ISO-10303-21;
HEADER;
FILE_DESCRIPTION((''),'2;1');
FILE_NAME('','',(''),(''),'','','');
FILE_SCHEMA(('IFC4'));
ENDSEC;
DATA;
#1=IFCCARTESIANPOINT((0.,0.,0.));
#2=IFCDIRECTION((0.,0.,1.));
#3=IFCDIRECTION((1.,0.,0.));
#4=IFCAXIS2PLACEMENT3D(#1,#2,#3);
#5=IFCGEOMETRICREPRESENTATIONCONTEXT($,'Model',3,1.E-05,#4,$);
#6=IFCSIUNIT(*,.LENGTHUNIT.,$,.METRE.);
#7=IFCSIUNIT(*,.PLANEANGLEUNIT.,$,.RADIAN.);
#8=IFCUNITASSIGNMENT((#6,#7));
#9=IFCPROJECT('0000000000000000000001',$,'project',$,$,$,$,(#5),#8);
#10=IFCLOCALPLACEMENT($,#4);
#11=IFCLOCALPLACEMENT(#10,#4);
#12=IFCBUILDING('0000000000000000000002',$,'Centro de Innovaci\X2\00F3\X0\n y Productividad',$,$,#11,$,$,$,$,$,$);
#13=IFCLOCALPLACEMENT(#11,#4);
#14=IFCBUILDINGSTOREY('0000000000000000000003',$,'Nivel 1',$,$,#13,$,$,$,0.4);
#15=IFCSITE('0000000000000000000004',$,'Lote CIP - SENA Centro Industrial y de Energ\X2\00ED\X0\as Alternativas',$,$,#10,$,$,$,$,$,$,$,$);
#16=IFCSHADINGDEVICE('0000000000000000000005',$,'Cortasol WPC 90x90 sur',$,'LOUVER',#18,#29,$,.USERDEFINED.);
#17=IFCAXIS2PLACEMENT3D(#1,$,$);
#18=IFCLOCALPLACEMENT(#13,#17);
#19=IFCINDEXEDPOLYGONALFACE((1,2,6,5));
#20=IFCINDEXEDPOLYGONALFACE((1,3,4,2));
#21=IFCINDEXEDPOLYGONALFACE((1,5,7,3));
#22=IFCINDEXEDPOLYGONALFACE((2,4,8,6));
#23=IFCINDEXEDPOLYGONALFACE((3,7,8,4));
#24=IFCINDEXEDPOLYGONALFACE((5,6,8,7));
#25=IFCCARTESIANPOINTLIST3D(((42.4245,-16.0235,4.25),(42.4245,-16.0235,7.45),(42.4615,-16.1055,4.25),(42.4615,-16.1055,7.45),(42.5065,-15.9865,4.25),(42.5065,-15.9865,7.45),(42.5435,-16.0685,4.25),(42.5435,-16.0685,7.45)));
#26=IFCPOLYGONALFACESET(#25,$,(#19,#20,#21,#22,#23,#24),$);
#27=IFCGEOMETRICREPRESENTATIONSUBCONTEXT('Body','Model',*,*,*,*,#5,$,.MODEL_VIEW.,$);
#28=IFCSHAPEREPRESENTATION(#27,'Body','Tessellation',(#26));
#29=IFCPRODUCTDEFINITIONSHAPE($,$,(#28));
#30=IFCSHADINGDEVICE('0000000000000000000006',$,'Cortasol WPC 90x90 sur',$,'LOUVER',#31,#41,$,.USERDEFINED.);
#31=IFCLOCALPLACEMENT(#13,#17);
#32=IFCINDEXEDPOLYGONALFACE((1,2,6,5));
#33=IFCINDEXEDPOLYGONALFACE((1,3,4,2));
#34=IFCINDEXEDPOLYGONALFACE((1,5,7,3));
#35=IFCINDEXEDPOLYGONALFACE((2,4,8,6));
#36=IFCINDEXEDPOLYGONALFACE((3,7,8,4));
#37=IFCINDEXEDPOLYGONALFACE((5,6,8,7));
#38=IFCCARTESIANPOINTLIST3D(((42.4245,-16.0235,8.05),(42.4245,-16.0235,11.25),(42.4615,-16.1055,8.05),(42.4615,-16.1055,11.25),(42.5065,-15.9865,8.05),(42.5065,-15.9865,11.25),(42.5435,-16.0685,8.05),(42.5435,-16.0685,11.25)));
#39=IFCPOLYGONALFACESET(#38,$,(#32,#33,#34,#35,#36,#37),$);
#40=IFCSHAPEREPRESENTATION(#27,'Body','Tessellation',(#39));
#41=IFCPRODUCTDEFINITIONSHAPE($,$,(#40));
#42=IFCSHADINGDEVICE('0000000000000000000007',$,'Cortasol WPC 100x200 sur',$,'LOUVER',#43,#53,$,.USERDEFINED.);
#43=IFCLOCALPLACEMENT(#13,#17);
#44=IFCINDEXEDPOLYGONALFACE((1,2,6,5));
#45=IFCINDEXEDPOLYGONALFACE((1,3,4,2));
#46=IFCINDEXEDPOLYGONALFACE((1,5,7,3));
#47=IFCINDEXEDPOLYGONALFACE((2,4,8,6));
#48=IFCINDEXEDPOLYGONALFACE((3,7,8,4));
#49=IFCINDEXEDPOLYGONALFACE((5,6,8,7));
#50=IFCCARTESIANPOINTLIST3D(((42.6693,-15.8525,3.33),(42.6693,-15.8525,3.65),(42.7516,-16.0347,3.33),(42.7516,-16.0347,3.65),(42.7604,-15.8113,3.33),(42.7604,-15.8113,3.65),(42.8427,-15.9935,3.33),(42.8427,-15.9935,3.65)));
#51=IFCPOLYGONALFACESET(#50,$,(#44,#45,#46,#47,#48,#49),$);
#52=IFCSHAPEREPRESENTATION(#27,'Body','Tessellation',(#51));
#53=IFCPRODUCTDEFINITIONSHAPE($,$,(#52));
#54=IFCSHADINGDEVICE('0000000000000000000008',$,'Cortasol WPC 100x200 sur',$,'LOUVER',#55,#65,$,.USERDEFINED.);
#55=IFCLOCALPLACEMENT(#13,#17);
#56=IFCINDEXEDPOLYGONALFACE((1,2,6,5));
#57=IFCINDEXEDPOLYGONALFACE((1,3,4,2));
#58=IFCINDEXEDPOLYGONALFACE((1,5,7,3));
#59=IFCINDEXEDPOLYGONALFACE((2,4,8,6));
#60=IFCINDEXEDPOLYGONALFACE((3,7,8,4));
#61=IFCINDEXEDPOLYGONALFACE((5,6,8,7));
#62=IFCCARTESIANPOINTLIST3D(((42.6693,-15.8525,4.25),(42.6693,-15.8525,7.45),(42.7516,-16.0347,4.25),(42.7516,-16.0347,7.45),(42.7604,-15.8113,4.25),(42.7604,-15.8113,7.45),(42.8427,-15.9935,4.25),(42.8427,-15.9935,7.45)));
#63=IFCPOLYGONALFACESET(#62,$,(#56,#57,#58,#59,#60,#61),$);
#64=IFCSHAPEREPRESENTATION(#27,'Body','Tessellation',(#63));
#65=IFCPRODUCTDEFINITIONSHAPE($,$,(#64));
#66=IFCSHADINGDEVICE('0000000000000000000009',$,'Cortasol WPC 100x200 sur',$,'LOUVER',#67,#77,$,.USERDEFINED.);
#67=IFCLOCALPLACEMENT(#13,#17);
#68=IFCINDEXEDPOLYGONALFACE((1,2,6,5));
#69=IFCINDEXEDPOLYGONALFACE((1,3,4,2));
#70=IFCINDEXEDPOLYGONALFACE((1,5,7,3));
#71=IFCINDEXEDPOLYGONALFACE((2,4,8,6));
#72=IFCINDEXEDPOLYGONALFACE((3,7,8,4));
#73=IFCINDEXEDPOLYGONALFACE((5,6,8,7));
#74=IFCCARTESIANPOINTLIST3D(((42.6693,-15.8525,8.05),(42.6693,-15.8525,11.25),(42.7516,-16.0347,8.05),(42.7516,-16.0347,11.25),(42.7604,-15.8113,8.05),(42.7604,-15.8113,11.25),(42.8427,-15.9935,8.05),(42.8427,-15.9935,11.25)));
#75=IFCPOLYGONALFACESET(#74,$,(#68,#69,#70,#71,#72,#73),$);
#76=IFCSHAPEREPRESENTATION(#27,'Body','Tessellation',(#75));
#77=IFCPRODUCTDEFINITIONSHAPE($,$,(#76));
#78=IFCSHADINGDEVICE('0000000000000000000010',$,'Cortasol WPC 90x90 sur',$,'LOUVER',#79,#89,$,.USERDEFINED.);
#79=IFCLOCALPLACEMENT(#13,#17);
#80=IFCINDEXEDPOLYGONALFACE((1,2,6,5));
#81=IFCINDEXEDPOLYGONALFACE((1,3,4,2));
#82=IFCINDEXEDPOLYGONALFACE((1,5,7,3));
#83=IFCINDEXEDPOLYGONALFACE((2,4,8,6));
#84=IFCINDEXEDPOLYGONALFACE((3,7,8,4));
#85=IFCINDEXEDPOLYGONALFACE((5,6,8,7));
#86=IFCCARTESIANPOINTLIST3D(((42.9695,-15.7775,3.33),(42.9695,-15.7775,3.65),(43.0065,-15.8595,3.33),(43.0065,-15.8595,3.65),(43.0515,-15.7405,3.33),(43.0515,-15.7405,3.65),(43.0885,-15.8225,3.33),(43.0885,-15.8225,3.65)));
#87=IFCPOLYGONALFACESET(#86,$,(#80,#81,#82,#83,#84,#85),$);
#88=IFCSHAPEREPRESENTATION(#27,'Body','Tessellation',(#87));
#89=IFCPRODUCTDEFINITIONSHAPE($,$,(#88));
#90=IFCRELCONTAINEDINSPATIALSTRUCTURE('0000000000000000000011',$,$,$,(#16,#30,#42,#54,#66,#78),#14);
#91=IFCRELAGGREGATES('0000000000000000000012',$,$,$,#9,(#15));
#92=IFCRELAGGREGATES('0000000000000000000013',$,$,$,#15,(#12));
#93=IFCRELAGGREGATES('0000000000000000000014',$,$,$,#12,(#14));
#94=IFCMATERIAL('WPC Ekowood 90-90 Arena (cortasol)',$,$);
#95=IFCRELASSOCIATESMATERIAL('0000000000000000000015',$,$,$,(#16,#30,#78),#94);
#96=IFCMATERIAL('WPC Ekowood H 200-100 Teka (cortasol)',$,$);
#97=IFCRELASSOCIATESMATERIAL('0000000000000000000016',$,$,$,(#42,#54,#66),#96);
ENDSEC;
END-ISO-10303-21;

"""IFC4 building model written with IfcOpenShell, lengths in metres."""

from ifc_helpers import new_model, si_unit, frame, origin_with_axes, place, context, subcontext, project, spatial, polyline, outline, extrude, material, element, save


model = new_model("IFC4")

# Units and contexts
model_context = context("Model", 3, precision=1e-05, world=origin_with_axes())
body_context = subcontext(model_context, "Body", "Model", "MODEL_VIEW")
ifc_project = project(units=[si_unit("LENGTHUNIT", "METRE"), si_unit("PLANEANGLEUNIT", "RADIAN")], contexts=[model_context])

# Site, building, storey
site_placement = place(None, origin_with_axes())
site = spatial("IfcSite", under=ifc_project, at=site_placement, Name="Lote CIP - SENA Centro Industrial y de Energías Alternativas")
building_placement = place(site_placement, origin_with_axes())
building = spatial("IfcBuilding", under=site, at=building_placement, Name="Centro de Innovación y Productividad")
storey_placement = place(building_placement, origin_with_axes())
storey = spatial("IfcBuildingStorey", under=building, at=storey_placement, Name="Nivel 1", Elevation=0.4)

# Shading devices
ifc_material_1 = material(Name="WPC Ekowood H 200-100 Teka (cortasol)")
ifc_material_2 = material(Name="WPC Ekowood 90-90 Arena (cortasol)")
shading_device_1_placement = place(storey_placement, origin_with_axes())
element("IfcShadingDevice", 1, at=shading_device_1_placement, inside=storey, material=ifc_material_2, Name="Cortasol WPC 90x90 sur", ObjectType="LOUVER", PredefinedType="USERDEFINED", context=body_context, shape_type="SweptSolid", body=[
    extrude(outline(polyline([(42.4615, -16.1055), (42.4245, -16.0235), (42.5065, -15.9865), (42.5435, -16.0685), (42.4615, -16.1055)])), frame((0.0, 0.0, 4.25)), (0.0, 0.0, 1.0), 3.2),
])
shading_device_2_placement = place(storey_placement, origin_with_axes())
element("IfcShadingDevice", 2, at=shading_device_2_placement, inside=storey, material=ifc_material_2, Name="Cortasol WPC 90x90 sur", ObjectType="LOUVER", PredefinedType="USERDEFINED", context=body_context, shape_type="SweptSolid", body=[
    extrude(outline(polyline([(42.4615, -16.1055), (42.4245, -16.0235), (42.5065, -15.9865), (42.5435, -16.0685), (42.4615, -16.1055)])), frame((0.0, 0.0, 8.05)), (0.0, 0.0, 1.0), 3.2),
])
shading_device_3_placement = place(storey_placement, origin_with_axes())
element("IfcShadingDevice", 3, at=shading_device_3_placement, inside=storey, material=ifc_material_1, Name="Cortasol WPC 100x200 sur", ObjectType="LOUVER", PredefinedType="USERDEFINED", context=body_context, shape_type="SweptSolid", body=[
    extrude(outline(polyline([(42.7516, -16.0347), (42.6693, -15.8525), (42.7604, -15.8113), (42.8427, -15.9935), (42.7516, -16.0347)])), frame((0.0, 0.0, 3.33)), (0.0, 0.0, 1.0), 0.32),
])
shading_device_4_placement = place(storey_placement, origin_with_axes())
element("IfcShadingDevice", 4, at=shading_device_4_placement, inside=storey, material=ifc_material_1, Name="Cortasol WPC 100x200 sur", ObjectType="LOUVER", PredefinedType="USERDEFINED", context=body_context, shape_type="SweptSolid", body=[
    extrude(outline(polyline([(42.7516, -16.0347), (42.6693, -15.8525), (42.7604, -15.8113), (42.8427, -15.9935), (42.7516, -16.0347)])), frame((0.0, 0.0, 4.25)), (0.0, 0.0, 1.0), 3.2),
])
shading_device_5_placement = place(storey_placement, origin_with_axes())
element("IfcShadingDevice", 5, at=shading_device_5_placement, inside=storey, material=ifc_material_1, Name="Cortasol WPC 100x200 sur", ObjectType="LOUVER", PredefinedType="USERDEFINED", context=body_context, shape_type="SweptSolid", body=[
    extrude(outline(polyline([(42.7516, -16.0347), (42.6693, -15.8525), (42.7604, -15.8113), (42.8427, -15.9935), (42.7516, -16.0347)])), frame((0.0, 0.0, 8.05)), (0.0, 0.0, 1.0), 3.2),
])
shading_device_6_placement = place(storey_placement, origin_with_axes())
element("IfcShadingDevice", 6, at=shading_device_6_placement, inside=storey, material=ifc_material_2, Name="Cortasol WPC 90x90 sur", ObjectType="LOUVER", PredefinedType="USERDEFINED", context=body_context, shape_type="SweptSolid", body=[
    extrude(outline(polyline([(43.0065, -15.8595), (42.9695, -15.7775), (43.0515, -15.7405), (43.0885, -15.8225), (43.0065, -15.8595)])), frame((0.0, 0.0, 3.33)), (0.0, 0.0, 1.0), 0.32),
])

save(model, "model.ifc")
